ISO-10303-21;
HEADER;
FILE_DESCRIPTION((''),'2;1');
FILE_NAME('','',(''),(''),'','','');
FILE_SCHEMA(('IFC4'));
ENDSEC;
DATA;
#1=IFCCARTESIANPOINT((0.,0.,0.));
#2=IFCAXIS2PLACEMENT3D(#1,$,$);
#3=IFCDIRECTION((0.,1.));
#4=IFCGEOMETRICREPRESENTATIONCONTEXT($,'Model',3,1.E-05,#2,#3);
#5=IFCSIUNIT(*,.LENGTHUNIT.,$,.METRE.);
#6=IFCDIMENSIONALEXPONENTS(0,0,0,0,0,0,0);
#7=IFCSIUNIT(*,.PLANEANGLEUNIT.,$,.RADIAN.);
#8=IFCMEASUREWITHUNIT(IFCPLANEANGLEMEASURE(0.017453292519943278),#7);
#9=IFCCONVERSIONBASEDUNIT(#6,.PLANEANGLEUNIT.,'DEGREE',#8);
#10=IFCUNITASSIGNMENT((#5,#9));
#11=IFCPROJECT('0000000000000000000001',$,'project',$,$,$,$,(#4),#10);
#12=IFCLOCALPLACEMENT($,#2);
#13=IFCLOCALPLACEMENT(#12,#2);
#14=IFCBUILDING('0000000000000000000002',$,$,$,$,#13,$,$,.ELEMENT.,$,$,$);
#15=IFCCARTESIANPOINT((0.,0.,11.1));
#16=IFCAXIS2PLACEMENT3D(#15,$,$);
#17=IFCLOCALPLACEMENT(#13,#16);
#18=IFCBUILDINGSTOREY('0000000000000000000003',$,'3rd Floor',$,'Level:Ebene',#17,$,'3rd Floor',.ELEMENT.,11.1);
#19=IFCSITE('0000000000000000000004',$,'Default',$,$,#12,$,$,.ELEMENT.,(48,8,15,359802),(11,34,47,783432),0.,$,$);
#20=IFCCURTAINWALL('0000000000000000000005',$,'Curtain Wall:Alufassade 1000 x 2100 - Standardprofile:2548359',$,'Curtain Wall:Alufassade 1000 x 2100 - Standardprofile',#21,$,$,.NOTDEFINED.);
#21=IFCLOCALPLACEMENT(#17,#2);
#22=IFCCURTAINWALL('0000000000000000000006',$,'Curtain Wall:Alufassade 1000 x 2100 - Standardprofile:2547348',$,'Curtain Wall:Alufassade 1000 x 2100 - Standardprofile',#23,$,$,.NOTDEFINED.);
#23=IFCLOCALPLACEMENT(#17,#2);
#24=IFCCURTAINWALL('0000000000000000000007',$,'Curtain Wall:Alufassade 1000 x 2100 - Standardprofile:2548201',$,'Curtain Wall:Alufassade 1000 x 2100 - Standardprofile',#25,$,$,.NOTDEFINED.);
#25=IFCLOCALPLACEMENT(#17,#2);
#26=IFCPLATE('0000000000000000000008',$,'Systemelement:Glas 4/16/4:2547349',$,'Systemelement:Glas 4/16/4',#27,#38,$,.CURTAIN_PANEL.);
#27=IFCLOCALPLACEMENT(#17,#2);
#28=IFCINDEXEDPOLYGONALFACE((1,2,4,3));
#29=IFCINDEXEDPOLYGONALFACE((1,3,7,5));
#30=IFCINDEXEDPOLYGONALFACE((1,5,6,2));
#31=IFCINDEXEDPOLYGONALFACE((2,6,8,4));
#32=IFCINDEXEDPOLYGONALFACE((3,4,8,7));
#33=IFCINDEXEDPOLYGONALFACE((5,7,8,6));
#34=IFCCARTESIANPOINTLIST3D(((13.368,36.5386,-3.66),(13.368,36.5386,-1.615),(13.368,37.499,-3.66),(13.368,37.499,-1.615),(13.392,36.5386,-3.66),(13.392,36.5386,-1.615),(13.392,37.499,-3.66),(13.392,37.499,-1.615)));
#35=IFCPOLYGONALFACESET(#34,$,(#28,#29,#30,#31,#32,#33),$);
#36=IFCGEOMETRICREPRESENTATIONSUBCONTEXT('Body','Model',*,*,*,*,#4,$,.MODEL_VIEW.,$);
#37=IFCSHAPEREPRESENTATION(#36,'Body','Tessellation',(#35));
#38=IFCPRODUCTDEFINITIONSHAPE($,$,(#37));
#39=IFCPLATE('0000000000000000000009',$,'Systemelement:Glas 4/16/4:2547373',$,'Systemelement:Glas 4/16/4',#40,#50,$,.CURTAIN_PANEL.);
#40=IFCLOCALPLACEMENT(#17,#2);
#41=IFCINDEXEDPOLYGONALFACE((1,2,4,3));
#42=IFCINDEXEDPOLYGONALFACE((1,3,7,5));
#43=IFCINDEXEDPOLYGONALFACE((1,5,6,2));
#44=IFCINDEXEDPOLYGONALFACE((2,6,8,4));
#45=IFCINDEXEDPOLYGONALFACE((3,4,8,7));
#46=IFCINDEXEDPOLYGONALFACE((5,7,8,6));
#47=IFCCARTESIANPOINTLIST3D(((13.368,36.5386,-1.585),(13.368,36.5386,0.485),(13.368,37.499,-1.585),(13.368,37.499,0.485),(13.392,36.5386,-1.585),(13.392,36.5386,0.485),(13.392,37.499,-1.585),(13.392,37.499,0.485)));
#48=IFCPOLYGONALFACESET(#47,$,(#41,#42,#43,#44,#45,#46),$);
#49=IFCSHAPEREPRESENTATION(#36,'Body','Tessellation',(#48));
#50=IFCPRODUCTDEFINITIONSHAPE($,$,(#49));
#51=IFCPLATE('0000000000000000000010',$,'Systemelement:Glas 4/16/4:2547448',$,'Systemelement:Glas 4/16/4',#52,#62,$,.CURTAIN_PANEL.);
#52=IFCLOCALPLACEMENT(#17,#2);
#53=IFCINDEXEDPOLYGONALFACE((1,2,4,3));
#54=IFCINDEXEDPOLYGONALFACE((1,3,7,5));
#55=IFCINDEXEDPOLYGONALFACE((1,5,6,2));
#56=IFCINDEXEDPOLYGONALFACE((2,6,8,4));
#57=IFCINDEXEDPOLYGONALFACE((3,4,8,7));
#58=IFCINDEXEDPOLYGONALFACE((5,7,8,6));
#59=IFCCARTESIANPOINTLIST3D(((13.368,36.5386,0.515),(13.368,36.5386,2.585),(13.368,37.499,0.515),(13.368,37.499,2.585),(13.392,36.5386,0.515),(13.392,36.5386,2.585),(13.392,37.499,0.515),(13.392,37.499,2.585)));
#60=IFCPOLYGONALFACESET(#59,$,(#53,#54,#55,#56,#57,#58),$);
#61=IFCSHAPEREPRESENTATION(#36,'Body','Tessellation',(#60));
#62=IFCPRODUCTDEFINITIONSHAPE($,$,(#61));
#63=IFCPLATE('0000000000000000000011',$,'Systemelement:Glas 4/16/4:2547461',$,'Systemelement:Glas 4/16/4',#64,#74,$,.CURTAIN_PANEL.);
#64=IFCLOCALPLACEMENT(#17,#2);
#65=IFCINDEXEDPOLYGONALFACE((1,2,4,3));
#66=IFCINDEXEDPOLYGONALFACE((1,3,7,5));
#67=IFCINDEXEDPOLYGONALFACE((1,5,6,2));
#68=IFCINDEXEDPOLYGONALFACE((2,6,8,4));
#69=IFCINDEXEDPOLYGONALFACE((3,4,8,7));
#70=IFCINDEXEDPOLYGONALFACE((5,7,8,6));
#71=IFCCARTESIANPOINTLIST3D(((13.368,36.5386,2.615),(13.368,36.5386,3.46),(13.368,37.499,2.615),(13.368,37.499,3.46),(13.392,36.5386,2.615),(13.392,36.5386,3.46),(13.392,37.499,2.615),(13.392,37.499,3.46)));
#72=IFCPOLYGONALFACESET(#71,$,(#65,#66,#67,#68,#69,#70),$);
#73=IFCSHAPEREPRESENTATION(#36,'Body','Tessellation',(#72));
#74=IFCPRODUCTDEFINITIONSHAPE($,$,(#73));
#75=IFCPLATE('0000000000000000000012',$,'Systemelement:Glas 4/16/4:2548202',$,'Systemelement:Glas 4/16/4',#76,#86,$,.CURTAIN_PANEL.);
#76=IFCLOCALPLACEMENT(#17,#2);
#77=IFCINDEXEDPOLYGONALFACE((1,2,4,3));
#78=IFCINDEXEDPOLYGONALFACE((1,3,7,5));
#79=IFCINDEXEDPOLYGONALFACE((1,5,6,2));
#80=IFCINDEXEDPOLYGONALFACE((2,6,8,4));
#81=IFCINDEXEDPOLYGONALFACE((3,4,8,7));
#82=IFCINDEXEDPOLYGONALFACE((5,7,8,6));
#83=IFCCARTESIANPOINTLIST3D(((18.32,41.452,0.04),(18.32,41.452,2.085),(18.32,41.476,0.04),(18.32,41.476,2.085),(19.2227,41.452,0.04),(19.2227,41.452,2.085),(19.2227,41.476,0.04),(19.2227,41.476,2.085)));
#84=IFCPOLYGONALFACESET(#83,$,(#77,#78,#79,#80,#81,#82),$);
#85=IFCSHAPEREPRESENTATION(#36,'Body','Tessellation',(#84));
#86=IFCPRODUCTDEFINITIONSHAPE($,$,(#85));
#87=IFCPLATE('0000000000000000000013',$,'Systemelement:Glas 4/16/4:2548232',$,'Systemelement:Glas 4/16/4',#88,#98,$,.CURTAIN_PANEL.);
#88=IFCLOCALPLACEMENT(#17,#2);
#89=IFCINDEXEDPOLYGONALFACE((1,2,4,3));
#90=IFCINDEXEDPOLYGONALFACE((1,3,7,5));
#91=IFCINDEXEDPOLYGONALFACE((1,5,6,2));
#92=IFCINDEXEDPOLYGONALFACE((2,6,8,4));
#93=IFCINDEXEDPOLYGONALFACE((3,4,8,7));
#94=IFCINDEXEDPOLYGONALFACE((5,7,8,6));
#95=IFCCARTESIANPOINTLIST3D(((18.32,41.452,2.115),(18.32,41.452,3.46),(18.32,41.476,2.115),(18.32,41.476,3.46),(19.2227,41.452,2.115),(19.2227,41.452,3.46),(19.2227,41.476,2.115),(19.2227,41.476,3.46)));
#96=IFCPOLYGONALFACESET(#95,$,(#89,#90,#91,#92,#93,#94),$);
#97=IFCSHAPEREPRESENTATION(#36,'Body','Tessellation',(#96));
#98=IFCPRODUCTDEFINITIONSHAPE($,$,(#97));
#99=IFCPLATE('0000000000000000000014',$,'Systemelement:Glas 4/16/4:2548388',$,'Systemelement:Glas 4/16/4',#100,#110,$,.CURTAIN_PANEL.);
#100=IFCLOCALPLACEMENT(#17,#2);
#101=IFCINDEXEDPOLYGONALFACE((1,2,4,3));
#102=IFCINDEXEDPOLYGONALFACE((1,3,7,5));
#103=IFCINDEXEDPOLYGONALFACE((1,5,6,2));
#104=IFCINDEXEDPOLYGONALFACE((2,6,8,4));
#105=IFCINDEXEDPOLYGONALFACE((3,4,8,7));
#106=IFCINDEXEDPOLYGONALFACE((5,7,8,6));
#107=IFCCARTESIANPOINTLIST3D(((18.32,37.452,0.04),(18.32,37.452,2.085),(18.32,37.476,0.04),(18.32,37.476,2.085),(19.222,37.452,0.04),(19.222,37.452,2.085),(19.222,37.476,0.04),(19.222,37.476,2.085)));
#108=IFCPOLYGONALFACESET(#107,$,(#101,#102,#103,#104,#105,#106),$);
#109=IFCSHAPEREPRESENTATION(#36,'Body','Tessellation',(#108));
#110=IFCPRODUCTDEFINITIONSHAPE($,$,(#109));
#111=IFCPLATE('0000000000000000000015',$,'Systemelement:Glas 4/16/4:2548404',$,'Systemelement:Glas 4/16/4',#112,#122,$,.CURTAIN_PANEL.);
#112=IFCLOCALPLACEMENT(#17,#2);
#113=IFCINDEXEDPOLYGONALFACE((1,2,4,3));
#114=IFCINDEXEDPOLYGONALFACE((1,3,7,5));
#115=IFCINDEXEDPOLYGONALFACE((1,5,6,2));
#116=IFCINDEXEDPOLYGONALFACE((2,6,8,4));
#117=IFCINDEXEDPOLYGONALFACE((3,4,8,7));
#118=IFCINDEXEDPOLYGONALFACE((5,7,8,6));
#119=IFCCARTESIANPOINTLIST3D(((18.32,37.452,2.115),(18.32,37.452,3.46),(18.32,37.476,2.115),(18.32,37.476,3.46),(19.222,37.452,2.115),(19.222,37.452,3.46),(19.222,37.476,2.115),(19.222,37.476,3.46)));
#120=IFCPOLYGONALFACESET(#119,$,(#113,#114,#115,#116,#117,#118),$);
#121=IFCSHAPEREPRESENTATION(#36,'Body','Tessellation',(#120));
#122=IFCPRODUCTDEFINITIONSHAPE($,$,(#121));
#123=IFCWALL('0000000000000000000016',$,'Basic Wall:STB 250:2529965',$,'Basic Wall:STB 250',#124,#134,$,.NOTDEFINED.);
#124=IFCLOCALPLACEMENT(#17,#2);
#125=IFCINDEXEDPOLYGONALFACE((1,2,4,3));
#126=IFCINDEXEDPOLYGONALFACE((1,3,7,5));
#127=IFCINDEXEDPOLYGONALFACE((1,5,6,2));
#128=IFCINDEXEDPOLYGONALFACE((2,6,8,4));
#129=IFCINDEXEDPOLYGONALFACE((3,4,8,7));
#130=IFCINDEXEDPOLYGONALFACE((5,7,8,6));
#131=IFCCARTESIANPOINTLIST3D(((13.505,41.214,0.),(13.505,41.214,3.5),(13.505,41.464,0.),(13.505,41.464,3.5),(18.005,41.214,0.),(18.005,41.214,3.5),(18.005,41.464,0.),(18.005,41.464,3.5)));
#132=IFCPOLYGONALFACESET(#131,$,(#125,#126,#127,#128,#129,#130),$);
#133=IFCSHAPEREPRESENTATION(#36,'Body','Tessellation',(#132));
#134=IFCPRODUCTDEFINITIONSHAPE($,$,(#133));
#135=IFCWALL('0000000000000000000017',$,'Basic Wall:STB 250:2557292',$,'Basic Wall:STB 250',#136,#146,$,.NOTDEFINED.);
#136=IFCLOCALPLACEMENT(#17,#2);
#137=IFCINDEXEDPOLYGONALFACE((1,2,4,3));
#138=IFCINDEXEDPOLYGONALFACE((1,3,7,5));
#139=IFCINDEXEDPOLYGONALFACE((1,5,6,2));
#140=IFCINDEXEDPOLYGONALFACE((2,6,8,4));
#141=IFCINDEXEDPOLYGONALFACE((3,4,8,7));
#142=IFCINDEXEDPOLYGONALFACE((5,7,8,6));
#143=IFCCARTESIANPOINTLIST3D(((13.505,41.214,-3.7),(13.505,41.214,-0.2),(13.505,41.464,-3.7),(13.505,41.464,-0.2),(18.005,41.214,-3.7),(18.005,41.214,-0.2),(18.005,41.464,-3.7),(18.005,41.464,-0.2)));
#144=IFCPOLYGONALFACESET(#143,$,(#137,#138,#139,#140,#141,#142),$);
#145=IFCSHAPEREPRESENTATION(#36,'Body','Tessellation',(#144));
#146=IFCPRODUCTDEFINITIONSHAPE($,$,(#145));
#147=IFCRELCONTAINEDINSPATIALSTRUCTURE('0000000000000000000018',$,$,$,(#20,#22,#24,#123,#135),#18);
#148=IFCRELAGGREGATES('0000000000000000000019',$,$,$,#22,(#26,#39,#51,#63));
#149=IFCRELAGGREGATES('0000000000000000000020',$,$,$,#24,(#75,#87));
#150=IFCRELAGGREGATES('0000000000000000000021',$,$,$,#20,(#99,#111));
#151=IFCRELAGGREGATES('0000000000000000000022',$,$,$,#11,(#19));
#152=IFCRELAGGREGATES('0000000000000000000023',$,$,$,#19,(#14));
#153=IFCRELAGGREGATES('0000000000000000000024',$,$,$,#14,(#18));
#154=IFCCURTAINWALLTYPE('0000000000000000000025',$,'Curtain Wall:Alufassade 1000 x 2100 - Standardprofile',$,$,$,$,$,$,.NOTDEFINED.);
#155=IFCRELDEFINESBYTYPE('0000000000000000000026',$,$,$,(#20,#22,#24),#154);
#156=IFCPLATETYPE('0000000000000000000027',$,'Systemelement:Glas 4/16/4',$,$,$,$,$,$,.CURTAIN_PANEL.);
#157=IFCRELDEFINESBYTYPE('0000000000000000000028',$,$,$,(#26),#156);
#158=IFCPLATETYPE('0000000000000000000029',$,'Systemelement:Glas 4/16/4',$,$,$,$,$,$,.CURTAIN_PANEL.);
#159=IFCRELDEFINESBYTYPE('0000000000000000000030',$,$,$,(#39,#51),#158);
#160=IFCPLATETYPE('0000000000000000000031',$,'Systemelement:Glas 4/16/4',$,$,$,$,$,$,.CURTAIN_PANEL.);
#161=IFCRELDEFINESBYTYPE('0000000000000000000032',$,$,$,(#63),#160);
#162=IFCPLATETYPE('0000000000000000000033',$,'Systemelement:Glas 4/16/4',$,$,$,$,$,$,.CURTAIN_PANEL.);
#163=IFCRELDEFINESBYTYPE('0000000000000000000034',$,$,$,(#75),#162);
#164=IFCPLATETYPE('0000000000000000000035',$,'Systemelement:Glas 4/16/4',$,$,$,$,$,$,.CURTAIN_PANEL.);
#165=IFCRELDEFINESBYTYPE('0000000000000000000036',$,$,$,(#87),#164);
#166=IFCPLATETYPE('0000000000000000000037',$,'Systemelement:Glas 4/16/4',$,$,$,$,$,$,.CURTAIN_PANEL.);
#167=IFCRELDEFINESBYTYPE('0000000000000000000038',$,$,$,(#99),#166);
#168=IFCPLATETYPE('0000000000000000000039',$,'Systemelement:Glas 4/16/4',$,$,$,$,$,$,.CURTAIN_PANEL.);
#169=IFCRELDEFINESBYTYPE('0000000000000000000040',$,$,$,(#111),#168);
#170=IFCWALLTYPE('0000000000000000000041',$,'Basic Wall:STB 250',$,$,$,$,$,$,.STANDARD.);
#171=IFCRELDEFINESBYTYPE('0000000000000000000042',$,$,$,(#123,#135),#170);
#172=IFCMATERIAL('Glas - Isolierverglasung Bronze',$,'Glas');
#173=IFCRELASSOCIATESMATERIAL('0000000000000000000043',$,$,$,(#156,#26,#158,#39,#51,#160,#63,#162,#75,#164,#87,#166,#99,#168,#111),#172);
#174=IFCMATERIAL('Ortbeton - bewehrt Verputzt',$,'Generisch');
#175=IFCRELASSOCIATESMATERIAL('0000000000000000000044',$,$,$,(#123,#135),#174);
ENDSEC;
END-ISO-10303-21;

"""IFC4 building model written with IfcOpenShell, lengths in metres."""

from ifc_helpers import new_model, entity, si_unit, converted_unit, direction, frame, origin, place, context, subcontext, project, spatial, indexed_curve, outline, extrude, source, transform, mapped, material, type_object, type_shapes, element, aggregate, save


model = new_model("IFC4")

# Units and contexts
model_context = context("Model", 3, precision=1e-05, world=origin(), true_north=direction((0.0, 1.0)))
body_context = subcontext(model_context, "Body", "Model", "MODEL_VIEW")
ifc_project = project(units=[si_unit("LENGTHUNIT", "METRE"), converted_unit("PLANEANGLEUNIT", "DEGREE", entity("IfcPlaneAngleMeasure", 0.017453292519943278), si_unit("PLANEANGLEUNIT", "RADIAN"), dimensions=[0, 0, 0, 0, 0, 0, 0])], contexts=[model_context])

# Site, building, storey
site_placement = place(None, origin())
site = spatial("IfcSite", under=ifc_project, at=site_placement, Name="Default", CompositionType="ELEMENT", RefLatitude=(48, 8, 15, 359802), RefLongitude=(11, 34, 47, 783432), RefElevation=0.0)
building_placement = place(site_placement, origin())
building = spatial("IfcBuilding", under=site, at=building_placement, CompositionType="ELEMENT")
storey_placement = place(building_placement, frame((0.0, 0.0, 11.1)))
storey = spatial("IfcBuildingStorey", under=building, at=storey_placement, Name="3rd Floor", ObjectType="Level:Ebene", LongName="3rd Floor", CompositionType="ELEMENT", Elevation=11.1)

# Curtain walls
curtain_wall_type = type_object("IfcCurtainWallType", Name="Curtain Wall:Alufassade 1000 x 2100 - Standardprofile", PredefinedType="NOTDEFINED")
curtain_wall_1_placement = place(storey_placement, frame((0.0, 0.0, -11.1)))
curtain_wall_1 = element("IfcCurtainWall", 1, at=curtain_wall_1_placement, inside=storey, type_object=curtain_wall_type, Name="Curtain Wall:Alufassade 1000 x 2100 - Standardprofile:2548359", ObjectType="Curtain Wall:Alufassade 1000 x 2100 - Standardprofile", PredefinedType="NOTDEFINED")
curtain_wall_2_placement = place(storey_placement, frame((0.0, 0.0, -11.1)))
curtain_wall_2 = element("IfcCurtainWall", 2, at=curtain_wall_2_placement, inside=storey, type_object=curtain_wall_type, Name="Curtain Wall:Alufassade 1000 x 2100 - Standardprofile:2547348", ObjectType="Curtain Wall:Alufassade 1000 x 2100 - Standardprofile", PredefinedType="NOTDEFINED")
curtain_wall_3_placement = place(storey_placement, frame((0.0, 0.0, -11.1)))
curtain_wall_3 = element("IfcCurtainWall", 3, at=curtain_wall_3_placement, inside=storey, type_object=curtain_wall_type, Name="Curtain Wall:Alufassade 1000 x 2100 - Standardprofile:2548201", ObjectType="Curtain Wall:Alufassade 1000 x 2100 - Standardprofile", PredefinedType="NOTDEFINED")

# Plates
ifc_material_1 = material(Name="Glas - Isolierverglasung Bronze", Category="Glas")
plate_type_1 = type_object("IfcPlateType", Name="Systemelement:Glas 4/16/4", PredefinedType="CURTAIN_PANEL", material=ifc_material_1)
shared_shape_1 = source(origin(), body_context, "Body", "SweptSolid", [
    extrude(outline(indexed_curve([(-0.012, -0.4802), (0.012, -0.4802), (0.012, 0.4802), (-0.012, 0.4802), (-0.012, -0.4802)], self_intersect=False)), frame((0.0, 0.0, 0.0), z_axis=(0.0, 0.0, 1.0), x_axis=(0.0, 1.0, 0.0)), (0.0, 0.0, 1.0), 2.045),
])
type_shapes(plate_type_1, [shared_shape_1])
plate_1_placement = place(curtain_wall_2_placement, frame((13.38, 37.0188, 7.44), z_axis=(0.0, 0.0, 1.0), x_axis=(0.0, -1.0, 0.0)))
plate_1 = element("IfcPlate", 4, at=plate_1_placement, type_object=plate_type_1, material=ifc_material_1, Name="Systemelement:Glas 4/16/4:2547349", ObjectType="Systemelement:Glas 4/16/4", PredefinedType="CURTAIN_PANEL", context=body_context, shape_type="MappedRepresentation", body=[
    mapped(shared_shape_1, transform((0.0, 0.0, 0.0), scale=1.0)),
])
plate_type_2 = type_object("IfcPlateType", Name="Systemelement:Glas 4/16/4", PredefinedType="CURTAIN_PANEL", material=ifc_material_1)
shared_shape_2 = source(origin(), body_context, "Body", "SweptSolid", [
    extrude(outline(indexed_curve([(-0.012, -0.4802), (0.012, -0.4802), (0.012, 0.4802), (-0.012, 0.4802), (-0.012, -0.4802)], self_intersect=False)), frame((0.0, 0.0, 0.0), z_axis=(0.0, 0.0, 1.0), x_axis=(0.0, 1.0, 0.0)), (0.0, 0.0, 1.0), 2.07),
])
type_shapes(plate_type_2, [shared_shape_2])
plate_2_placement = place(curtain_wall_2_placement, frame((13.38, 37.0188, 9.515), z_axis=(0.0, 0.0, 1.0), x_axis=(0.0, -1.0, 0.0)))
plate_2 = element("IfcPlate", 5, at=plate_2_placement, type_object=plate_type_2, material=ifc_material_1, Name="Systemelement:Glas 4/16/4:2547373", ObjectType="Systemelement:Glas 4/16/4", PredefinedType="CURTAIN_PANEL", context=body_context, shape_type="MappedRepresentation", body=[
    mapped(shared_shape_2, transform((0.0, 0.0, 0.0), scale=1.0)),
])
plate_3_placement = place(curtain_wall_2_placement, frame((13.38, 37.0188, 11.615), z_axis=(0.0, 0.0, 1.0), x_axis=(0.0, -1.0, 0.0)))
plate_3 = element("IfcPlate", 6, at=plate_3_placement, type_object=plate_type_2, material=ifc_material_1, Name="Systemelement:Glas 4/16/4:2547448", ObjectType="Systemelement:Glas 4/16/4", PredefinedType="CURTAIN_PANEL", context=body_context, shape_type="MappedRepresentation", body=[
    mapped(shared_shape_2, transform((0.0, 0.0, 0.0), scale=1.0)),
])
plate_type_3 = type_object("IfcPlateType", Name="Systemelement:Glas 4/16/4", PredefinedType="CURTAIN_PANEL", material=ifc_material_1)
shared_shape_3 = source(origin(), body_context, "Body", "SweptSolid", [
    extrude(outline(indexed_curve([(-0.012, -0.4802), (0.012, -0.4802), (0.012, 0.4802), (-0.012, 0.4802), (-0.012, -0.4802)], self_intersect=False)), frame((0.0, 0.0, 0.0), z_axis=(0.0, 0.0, 1.0), x_axis=(0.0, 1.0, 0.0)), (0.0, 0.0, 1.0), 0.845),
])
type_shapes(plate_type_3, [shared_shape_3])
plate_4_placement = place(curtain_wall_2_placement, frame((13.38, 37.0188, 13.715), z_axis=(0.0, 0.0, 1.0), x_axis=(0.0, -1.0, 0.0)))
plate_4 = element("IfcPlate", 7, at=plate_4_placement, type_object=plate_type_3, material=ifc_material_1, Name="Systemelement:Glas 4/16/4:2547461", ObjectType="Systemelement:Glas 4/16/4", PredefinedType="CURTAIN_PANEL", context=body_context, shape_type="MappedRepresentation", body=[
    mapped(shared_shape_3, transform((0.0, 0.0, 0.0), scale=1.0)),
])
aggregate(curtain_wall_2, [plate_1, plate_2, plate_3, plate_4])
plate_type_4 = type_object("IfcPlateType", Name="Systemelement:Glas 4/16/4", PredefinedType="CURTAIN_PANEL", material=ifc_material_1)
shared_shape_4 = source(origin(), body_context, "Body", "SweptSolid", [
    extrude(outline(indexed_curve([(-0.012, -0.4513), (0.012, -0.4513), (0.012, 0.4513), (-0.012, 0.4513), (-0.012, -0.4513)], self_intersect=False)), frame((0.0, 0.0, 0.0), z_axis=(0.0, 0.0, 1.0), x_axis=(0.0, 1.0, 0.0)), (0.0, 0.0, 1.0), 2.045),
])
type_shapes(plate_type_4, [shared_shape_4])
plate_5_placement = place(curtain_wall_3_placement, frame((18.7713, 41.464, 11.14)))
plate_5 = element("IfcPlate", 8, at=plate_5_placement, type_object=plate_type_4, material=ifc_material_1, Name="Systemelement:Glas 4/16/4:2548202", ObjectType="Systemelement:Glas 4/16/4", PredefinedType="CURTAIN_PANEL", context=body_context, shape_type="MappedRepresentation", body=[
    mapped(shared_shape_4, transform((0.0, 0.0, 0.0), scale=1.0)),
])
plate_type_5 = type_object("IfcPlateType", Name="Systemelement:Glas 4/16/4", PredefinedType="CURTAIN_PANEL", material=ifc_material_1)
shared_shape_5 = source(origin(), body_context, "Body", "SweptSolid", [
    extrude(outline(indexed_curve([(-0.012, -0.4513), (0.012, -0.4513), (0.012, 0.4513), (-0.012, 0.4513), (-0.012, -0.4513)], self_intersect=False)), frame((0.0, 0.0, 0.0), z_axis=(0.0, 0.0, 1.0), x_axis=(0.0, 1.0, 0.0)), (0.0, 0.0, 1.0), 1.345),
])
type_shapes(plate_type_5, [shared_shape_5])
plate_6_placement = place(curtain_wall_3_placement, frame((18.7713, 41.464, 13.215)))
plate_6 = element("IfcPlate", 9, at=plate_6_placement, type_object=plate_type_5, material=ifc_material_1, Name="Systemelement:Glas 4/16/4:2548232", ObjectType="Systemelement:Glas 4/16/4", PredefinedType="CURTAIN_PANEL", context=body_context, shape_type="MappedRepresentation", body=[
    mapped(shared_shape_5, transform((0.0, 0.0, 0.0), scale=1.0)),
])
aggregate(curtain_wall_3, [plate_5, plate_6])
plate_type_6 = type_object("IfcPlateType", Name="Systemelement:Glas 4/16/4", PredefinedType="CURTAIN_PANEL", material=ifc_material_1)
shared_shape_6 = source(origin(), body_context, "Body", "SweptSolid", [
    extrude(outline(indexed_curve([(-0.012, -0.451), (0.012, -0.451), (0.012, 0.451), (-0.012, 0.451), (-0.012, -0.451)], self_intersect=False)), frame((0.0, 0.0, 0.0), z_axis=(0.0, 0.0, 1.0), x_axis=(0.0, 1.0, 0.0)), (0.0, 0.0, 1.0), 2.045),
])
type_shapes(plate_type_6, [shared_shape_6])
plate_7_placement = place(curtain_wall_1_placement, frame((18.771, 37.464, 11.14), z_axis=(0.0, 0.0, 1.0), x_axis=(-1.0, 0.0, 0.0)))
plate_7 = element("IfcPlate", 10, at=plate_7_placement, type_object=plate_type_6, material=ifc_material_1, Name="Systemelement:Glas 4/16/4:2548388", ObjectType="Systemelement:Glas 4/16/4", PredefinedType="CURTAIN_PANEL", context=body_context, shape_type="MappedRepresentation", body=[
    mapped(shared_shape_6, transform((0.0, 0.0, 0.0), scale=1.0)),
])
plate_type_7 = type_object("IfcPlateType", Name="Systemelement:Glas 4/16/4", PredefinedType="CURTAIN_PANEL", material=ifc_material_1)
shared_shape_7 = source(origin(), body_context, "Body", "SweptSolid", [
    extrude(outline(indexed_curve([(-0.012, -0.451), (0.012, -0.451), (0.012, 0.451), (-0.012, 0.451), (-0.012, -0.451)], self_intersect=False)), frame((0.0, 0.0, 0.0), z_axis=(0.0, 0.0, 1.0), x_axis=(0.0, 1.0, 0.0)), (0.0, 0.0, 1.0), 1.345),
])
type_shapes(plate_type_7, [shared_shape_7])
plate_8_placement = place(curtain_wall_1_placement, frame((18.771, 37.464, 13.215), z_axis=(0.0, 0.0, 1.0), x_axis=(-1.0, 0.0, 0.0)))
plate_8 = element("IfcPlate", 11, at=plate_8_placement, type_object=plate_type_7, material=ifc_material_1, Name="Systemelement:Glas 4/16/4:2548404", ObjectType="Systemelement:Glas 4/16/4", PredefinedType="CURTAIN_PANEL", context=body_context, shape_type="MappedRepresentation", body=[
    mapped(shared_shape_7, transform((0.0, 0.0, 0.0), scale=1.0)),
])
aggregate(curtain_wall_1, [plate_7, plate_8])

# Walls
ifc_material_2 = material(Name="Ortbeton - bewehrt Verputzt", Category="Generisch")
wall_type = type_object("IfcWallType", Name="Basic Wall:STB 250", PredefinedType="STANDARD")
wall_1_placement = place(storey_placement, frame((13.505, 41.339, 0.0)))
element("IfcWall", 12, at=wall_1_placement, inside=storey, type_object=wall_type, material=ifc_material_2, Name="Basic Wall:STB 250:2529965", ObjectType="Basic Wall:STB 250", PredefinedType="NOTDEFINED", context=body_context, shape_type="SweptSolid", body=[
    extrude(outline(indexed_curve([(4.5, -0.125), (4.5, 0.125), (0.0, 0.125), (0.0, -0.125), (4.5, -0.125)], self_intersect=False)), origin(), (0.0, 0.0, 1.0), 3.5),
])
wall_2_placement = place(storey_placement, frame((13.505, 41.339, -3.7)))
element("IfcWall", 13, at=wall_2_placement, inside=storey, type_object=wall_type, material=ifc_material_2, Name="Basic Wall:STB 250:2557292", ObjectType="Basic Wall:STB 250", PredefinedType="NOTDEFINED", context=body_context, shape_type="SweptSolid", body=[
    extrude(outline(indexed_curve([(4.5, -0.125), (4.5, 0.125), (0.0, 0.125), (0.0, -0.125), (4.5, -0.125)], self_intersect=False)), origin(), (0.0, 0.0, 1.0), 3.5),
])

save(model, "model.ifc")
